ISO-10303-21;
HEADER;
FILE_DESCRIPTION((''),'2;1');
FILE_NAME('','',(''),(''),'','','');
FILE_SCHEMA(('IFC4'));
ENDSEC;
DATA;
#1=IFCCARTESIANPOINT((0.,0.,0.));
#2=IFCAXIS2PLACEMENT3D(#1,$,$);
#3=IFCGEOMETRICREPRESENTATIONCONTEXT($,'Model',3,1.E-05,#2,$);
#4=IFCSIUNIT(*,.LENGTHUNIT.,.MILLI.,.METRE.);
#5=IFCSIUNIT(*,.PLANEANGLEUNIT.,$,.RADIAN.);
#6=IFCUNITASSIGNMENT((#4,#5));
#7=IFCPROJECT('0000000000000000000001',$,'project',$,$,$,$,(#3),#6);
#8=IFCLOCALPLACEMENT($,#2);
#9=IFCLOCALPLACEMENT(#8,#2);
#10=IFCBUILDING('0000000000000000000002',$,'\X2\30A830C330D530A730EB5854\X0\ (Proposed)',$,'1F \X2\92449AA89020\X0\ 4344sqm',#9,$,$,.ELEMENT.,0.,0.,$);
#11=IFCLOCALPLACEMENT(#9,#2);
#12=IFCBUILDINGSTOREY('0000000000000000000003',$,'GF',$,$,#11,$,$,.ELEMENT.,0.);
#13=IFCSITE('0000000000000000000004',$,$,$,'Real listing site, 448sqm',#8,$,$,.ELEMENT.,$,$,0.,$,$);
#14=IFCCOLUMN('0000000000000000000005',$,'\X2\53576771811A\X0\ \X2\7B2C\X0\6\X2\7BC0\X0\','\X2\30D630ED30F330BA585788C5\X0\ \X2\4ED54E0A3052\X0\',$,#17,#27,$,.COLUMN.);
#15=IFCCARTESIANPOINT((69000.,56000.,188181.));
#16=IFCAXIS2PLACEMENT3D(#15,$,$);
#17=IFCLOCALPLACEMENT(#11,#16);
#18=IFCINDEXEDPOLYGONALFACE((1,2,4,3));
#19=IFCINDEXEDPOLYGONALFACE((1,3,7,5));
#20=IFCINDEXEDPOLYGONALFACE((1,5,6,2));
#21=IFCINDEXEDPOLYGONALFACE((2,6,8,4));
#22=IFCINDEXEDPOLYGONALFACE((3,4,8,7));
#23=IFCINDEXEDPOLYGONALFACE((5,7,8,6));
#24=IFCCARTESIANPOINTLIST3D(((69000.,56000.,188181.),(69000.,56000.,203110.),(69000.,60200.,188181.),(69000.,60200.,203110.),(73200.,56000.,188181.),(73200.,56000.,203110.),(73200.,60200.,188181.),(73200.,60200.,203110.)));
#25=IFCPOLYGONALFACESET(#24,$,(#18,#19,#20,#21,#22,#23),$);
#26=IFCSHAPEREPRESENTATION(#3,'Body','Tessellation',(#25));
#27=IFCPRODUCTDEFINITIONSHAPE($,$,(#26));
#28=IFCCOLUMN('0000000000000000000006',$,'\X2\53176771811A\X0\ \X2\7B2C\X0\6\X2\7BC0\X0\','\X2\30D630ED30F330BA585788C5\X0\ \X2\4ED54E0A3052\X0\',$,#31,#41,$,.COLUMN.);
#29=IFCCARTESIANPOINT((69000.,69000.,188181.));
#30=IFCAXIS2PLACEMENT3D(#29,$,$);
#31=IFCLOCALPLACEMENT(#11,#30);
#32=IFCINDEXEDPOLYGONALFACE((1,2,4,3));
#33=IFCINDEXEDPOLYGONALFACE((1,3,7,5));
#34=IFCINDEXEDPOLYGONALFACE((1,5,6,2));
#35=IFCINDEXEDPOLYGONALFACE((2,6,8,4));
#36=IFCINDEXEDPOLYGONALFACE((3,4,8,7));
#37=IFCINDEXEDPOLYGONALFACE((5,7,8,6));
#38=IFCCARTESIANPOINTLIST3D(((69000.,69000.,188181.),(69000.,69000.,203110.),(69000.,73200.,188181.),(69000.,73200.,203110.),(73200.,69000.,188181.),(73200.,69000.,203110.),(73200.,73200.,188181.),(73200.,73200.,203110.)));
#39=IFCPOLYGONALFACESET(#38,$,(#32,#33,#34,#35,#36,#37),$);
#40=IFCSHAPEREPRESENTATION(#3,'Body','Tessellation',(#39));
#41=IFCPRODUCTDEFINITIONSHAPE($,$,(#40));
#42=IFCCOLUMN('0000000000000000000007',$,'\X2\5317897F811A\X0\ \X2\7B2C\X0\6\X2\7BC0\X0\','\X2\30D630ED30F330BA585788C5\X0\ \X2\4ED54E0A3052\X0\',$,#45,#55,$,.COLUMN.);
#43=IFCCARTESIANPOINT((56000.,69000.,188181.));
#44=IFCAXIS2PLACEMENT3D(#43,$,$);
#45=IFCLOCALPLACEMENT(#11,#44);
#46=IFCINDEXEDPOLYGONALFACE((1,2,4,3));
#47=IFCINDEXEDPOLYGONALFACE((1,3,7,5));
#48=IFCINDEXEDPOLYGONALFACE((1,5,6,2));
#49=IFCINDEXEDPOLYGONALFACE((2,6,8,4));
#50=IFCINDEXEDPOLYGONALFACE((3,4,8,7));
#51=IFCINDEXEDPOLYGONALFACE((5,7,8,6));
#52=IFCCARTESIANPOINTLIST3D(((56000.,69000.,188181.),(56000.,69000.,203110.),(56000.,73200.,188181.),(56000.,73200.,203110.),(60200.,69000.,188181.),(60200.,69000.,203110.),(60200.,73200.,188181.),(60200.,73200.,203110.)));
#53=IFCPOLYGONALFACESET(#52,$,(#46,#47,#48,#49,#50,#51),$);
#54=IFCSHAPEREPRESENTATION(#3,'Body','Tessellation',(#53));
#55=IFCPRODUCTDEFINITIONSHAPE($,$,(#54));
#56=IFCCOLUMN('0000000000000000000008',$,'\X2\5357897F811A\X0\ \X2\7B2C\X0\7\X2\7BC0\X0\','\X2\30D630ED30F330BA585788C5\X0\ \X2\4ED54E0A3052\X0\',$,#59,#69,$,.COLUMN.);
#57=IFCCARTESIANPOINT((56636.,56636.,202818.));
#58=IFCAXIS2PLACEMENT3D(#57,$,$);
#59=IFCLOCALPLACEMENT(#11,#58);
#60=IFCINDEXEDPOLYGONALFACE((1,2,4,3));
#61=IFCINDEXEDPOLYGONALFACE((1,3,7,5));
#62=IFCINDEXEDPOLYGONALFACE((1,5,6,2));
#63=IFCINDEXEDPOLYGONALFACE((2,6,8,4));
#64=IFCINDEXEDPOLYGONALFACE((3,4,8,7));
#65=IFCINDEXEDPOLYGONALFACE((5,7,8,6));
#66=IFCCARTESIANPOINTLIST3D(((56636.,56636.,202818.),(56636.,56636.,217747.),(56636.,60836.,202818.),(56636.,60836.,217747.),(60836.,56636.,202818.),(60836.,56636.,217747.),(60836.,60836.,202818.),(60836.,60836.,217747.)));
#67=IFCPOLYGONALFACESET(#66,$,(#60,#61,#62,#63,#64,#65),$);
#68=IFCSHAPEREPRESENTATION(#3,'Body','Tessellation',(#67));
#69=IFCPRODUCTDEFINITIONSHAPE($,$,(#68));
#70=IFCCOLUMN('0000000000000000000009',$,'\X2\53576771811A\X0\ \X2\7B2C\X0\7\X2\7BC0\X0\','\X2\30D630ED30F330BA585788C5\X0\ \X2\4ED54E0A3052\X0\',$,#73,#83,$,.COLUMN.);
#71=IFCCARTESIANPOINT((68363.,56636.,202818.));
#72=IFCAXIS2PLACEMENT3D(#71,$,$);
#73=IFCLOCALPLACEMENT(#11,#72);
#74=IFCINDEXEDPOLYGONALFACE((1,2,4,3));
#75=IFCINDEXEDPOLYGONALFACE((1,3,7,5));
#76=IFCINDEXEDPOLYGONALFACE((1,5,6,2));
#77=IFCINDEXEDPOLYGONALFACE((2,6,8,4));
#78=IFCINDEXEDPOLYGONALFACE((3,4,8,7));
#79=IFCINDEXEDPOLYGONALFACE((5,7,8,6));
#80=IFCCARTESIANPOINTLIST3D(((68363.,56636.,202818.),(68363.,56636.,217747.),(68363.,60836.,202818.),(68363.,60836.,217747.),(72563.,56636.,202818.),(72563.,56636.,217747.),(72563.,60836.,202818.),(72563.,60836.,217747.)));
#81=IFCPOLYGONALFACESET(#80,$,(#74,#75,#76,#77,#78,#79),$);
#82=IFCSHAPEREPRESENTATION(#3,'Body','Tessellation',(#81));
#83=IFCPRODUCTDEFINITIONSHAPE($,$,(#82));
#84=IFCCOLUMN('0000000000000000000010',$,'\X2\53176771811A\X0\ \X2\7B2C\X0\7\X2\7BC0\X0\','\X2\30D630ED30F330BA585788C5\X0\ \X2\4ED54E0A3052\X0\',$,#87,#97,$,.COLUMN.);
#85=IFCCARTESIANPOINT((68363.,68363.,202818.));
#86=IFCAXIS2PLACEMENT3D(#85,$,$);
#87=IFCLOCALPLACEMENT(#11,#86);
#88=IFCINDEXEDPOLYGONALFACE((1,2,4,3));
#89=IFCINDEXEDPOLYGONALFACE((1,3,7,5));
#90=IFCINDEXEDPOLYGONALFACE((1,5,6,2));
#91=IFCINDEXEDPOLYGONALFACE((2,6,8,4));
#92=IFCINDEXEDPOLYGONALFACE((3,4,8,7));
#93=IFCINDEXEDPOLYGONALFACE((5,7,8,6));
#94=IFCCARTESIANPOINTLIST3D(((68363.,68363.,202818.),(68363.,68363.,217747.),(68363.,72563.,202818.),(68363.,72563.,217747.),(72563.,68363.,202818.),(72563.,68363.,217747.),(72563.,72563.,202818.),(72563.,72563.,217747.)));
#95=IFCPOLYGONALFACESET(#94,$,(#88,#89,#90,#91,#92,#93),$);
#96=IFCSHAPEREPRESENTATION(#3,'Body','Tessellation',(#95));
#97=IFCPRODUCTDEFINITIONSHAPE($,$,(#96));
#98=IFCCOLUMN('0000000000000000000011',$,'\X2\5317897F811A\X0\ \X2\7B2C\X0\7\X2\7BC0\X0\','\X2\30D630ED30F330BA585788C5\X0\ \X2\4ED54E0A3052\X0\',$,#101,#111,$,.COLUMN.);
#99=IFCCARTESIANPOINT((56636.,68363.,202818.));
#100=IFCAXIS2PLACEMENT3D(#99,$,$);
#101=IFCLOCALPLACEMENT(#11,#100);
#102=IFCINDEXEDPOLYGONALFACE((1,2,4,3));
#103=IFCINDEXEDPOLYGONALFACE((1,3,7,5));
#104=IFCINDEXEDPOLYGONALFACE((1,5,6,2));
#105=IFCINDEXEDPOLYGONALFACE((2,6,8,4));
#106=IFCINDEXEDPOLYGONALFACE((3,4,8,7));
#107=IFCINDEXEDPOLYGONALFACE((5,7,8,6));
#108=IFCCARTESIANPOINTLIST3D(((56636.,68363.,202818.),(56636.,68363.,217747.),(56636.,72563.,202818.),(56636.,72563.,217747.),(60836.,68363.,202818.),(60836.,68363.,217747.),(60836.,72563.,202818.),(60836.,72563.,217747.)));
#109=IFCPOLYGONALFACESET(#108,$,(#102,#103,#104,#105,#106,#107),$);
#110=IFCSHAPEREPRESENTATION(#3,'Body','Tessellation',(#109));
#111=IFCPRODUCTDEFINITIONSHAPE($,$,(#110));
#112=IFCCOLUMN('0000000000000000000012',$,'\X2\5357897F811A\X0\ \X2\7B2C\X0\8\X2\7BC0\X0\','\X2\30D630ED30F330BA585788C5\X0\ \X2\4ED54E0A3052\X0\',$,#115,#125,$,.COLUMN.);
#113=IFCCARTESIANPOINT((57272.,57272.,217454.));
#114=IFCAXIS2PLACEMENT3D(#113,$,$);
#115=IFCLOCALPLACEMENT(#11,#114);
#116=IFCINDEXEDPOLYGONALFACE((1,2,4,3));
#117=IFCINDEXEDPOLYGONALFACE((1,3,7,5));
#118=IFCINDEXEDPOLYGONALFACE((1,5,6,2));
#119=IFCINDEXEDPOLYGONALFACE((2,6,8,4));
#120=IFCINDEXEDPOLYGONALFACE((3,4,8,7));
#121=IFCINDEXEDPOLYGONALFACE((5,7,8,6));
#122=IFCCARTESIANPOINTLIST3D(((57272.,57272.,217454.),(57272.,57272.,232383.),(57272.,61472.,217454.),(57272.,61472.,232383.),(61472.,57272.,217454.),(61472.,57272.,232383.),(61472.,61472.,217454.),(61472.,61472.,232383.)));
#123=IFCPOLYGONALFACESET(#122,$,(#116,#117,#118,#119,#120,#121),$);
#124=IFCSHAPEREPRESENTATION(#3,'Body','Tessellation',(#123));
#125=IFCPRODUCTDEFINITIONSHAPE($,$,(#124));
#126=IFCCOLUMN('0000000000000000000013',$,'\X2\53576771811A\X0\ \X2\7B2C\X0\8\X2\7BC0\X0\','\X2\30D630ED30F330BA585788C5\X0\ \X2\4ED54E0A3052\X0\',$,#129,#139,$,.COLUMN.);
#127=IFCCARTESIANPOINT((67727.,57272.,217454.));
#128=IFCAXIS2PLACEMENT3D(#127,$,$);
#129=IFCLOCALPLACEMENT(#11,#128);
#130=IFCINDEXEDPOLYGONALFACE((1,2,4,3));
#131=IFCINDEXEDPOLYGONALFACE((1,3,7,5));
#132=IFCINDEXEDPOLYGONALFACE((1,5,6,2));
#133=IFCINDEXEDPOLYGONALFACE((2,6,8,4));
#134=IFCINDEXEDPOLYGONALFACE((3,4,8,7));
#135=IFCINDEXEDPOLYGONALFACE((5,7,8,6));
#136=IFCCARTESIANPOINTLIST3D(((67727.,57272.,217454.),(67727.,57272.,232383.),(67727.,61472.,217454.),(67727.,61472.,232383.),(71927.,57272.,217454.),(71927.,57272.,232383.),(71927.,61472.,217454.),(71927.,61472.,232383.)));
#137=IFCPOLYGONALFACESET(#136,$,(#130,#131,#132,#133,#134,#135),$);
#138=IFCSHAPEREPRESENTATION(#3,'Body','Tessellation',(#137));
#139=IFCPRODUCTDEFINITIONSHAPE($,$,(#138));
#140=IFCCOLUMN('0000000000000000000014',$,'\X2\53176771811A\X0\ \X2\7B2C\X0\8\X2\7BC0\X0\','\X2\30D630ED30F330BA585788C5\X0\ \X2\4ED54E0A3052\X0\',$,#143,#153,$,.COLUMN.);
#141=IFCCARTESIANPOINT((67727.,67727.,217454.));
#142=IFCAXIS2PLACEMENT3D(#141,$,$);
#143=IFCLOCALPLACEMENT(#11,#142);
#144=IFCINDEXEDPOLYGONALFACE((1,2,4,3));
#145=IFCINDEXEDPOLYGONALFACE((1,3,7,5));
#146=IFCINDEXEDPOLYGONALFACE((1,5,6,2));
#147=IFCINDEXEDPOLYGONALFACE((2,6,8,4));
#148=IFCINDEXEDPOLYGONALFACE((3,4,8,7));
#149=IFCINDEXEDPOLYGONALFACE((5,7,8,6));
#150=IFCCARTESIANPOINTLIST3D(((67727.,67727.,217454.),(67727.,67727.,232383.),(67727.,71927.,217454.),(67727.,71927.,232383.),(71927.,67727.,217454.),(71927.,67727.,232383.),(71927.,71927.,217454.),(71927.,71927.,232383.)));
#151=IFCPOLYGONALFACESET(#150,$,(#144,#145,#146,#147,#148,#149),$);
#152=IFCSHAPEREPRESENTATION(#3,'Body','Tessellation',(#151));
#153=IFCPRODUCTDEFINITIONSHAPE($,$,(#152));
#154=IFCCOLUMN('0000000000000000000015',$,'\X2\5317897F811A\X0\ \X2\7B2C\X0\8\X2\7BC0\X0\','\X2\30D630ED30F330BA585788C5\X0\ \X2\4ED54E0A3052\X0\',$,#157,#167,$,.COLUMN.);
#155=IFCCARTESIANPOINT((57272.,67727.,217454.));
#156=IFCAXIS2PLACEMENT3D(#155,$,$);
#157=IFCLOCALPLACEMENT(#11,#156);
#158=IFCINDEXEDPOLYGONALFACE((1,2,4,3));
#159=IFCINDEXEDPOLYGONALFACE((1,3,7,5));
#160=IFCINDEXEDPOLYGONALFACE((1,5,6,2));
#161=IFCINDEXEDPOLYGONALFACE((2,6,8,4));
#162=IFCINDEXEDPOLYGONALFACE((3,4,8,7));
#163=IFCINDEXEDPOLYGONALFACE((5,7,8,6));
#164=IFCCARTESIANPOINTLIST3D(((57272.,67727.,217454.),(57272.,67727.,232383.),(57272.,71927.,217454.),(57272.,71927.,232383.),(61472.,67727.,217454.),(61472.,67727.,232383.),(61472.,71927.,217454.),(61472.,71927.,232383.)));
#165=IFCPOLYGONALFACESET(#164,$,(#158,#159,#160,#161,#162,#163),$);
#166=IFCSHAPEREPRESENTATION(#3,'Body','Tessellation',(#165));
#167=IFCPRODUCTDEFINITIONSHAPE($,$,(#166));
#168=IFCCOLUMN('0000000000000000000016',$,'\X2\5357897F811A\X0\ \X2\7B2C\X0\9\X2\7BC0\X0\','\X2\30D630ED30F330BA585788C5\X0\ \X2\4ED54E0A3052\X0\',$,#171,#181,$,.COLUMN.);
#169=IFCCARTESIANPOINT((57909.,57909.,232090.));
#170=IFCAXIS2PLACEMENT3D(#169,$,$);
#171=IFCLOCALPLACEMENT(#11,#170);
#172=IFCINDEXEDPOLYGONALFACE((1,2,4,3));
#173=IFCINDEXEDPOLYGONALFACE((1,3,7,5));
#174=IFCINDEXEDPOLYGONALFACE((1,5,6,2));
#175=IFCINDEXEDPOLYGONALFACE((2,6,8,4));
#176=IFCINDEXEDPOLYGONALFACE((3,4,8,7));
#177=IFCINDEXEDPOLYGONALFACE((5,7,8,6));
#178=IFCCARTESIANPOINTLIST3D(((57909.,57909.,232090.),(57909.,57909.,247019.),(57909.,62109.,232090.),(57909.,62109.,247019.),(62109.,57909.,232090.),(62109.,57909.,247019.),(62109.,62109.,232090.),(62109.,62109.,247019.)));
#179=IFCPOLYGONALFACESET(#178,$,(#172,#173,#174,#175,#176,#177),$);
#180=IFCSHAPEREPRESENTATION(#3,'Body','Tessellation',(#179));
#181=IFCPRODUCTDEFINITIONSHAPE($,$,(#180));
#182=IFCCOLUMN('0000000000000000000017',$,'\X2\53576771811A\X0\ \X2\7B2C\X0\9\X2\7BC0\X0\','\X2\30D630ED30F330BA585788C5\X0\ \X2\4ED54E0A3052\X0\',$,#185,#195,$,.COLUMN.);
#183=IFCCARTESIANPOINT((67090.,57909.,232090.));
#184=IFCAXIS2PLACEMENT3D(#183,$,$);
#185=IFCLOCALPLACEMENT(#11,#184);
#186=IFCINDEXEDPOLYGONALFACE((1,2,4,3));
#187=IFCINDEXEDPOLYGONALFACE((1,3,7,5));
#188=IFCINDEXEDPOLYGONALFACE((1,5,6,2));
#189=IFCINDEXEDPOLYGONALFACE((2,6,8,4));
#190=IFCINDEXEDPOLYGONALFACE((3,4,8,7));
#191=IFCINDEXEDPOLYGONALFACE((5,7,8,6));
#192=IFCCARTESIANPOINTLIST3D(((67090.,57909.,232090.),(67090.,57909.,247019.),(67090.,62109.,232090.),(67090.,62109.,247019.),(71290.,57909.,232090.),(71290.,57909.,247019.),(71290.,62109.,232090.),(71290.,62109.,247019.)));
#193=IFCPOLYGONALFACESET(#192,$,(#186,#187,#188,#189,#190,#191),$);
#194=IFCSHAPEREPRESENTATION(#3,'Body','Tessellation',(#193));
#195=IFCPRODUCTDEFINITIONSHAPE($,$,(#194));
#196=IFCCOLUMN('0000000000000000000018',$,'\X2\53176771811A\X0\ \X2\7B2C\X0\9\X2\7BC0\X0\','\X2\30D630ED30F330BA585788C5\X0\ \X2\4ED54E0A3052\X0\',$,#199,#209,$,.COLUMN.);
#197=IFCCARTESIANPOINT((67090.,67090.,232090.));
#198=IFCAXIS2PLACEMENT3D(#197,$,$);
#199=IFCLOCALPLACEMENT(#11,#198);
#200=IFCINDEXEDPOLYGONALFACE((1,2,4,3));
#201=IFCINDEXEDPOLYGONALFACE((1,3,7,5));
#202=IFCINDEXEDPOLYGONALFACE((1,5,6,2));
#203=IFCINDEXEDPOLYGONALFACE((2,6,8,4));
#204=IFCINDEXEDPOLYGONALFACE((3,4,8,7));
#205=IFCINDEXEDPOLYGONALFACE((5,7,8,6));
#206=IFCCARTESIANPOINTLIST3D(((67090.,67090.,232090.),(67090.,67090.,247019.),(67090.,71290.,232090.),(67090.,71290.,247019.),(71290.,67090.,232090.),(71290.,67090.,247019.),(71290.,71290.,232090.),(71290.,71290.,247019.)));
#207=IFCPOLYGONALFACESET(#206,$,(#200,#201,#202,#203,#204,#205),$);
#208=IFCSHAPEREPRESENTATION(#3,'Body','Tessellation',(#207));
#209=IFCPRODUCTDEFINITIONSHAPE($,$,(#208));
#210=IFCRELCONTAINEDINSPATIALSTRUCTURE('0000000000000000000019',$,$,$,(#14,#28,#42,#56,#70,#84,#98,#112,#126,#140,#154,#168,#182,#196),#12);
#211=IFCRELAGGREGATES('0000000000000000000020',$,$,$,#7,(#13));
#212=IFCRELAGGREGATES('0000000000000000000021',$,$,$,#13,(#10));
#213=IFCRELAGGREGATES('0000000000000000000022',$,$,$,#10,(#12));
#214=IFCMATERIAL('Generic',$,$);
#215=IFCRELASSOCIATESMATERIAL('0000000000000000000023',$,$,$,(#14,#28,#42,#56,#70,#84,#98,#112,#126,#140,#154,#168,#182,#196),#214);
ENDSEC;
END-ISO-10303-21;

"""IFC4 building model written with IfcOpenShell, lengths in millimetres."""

from ifc_helpers import new_model, si_unit, frame, frame_2d, origin, place, context, project, spatial, rectangle, extrude, material, element, save


model = new_model("IFC4")

# Units and contexts
model_context = context("Model", 3, precision=1e-05, world=origin())
ifc_project = project(units=[si_unit("LENGTHUNIT", "METRE", prefix="MILLI"), si_unit("PLANEANGLEUNIT", "RADIAN")], contexts=[model_context])

# Site, building, storey
site_placement = place(None, origin())
site = spatial("IfcSite", under=ifc_project, at=site_placement, ObjectType="Real listing site, 448sqm", CompositionType="ELEMENT", RefElevation=0.0)
building_placement = place(site_placement, origin())
building = spatial("IfcBuilding", under=site, at=building_placement, Name="エッフェル塔 (Proposed)", ObjectType="1F 鉄骨造 4344sqm", CompositionType="ELEMENT", ElevationOfRefHeight=0.0, ElevationOfTerrain=0.0)
storey_placement = place(building_placement, origin())
storey = spatial("IfcBuildingStorey", under=building, at=storey_placement, Name="GF", CompositionType="ELEMENT", Elevation=0.0)

# Columns
ifc_material_1 = material(Name="Generic")
column_1_placement = place(storey_placement, frame((69000.0, 56000.0, 188181.0)))
element("IfcColumn", 1, at=column_1_placement, inside=storey, material=ifc_material_1, Name="南東脚 第6節", Description="ブロンズ塗装 仕上げ", PredefinedType="COLUMN", context=model_context, shape_type="SweptSolid", body=[
    extrude(rectangle(XDim=4200.0, YDim=4200.0, at=frame_2d((2100.0, 2100.0))), frame((69000.0, 56000.0, 188181.0)), (0.0, 0.0, 1.0), 14929.0),
])
column_2_placement = place(storey_placement, frame((69000.0, 69000.0, 188181.0)))
element("IfcColumn", 2, at=column_2_placement, inside=storey, material=ifc_material_1, Name="北東脚 第6節", Description="ブロンズ塗装 仕上げ", PredefinedType="COLUMN", context=model_context, shape_type="SweptSolid", body=[
    extrude(rectangle(XDim=4200.0, YDim=4200.0, at=frame_2d((2100.0, 2100.0))), frame((69000.0, 69000.0, 188181.0)), (0.0, 0.0, 1.0), 14929.0),
])
column_3_placement = place(storey_placement, frame((56000.0, 69000.0, 188181.0)))
element("IfcColumn", 3, at=column_3_placement, inside=storey, material=ifc_material_1, Name="北西脚 第6節", Description="ブロンズ塗装 仕上げ", PredefinedType="COLUMN", context=model_context, shape_type="SweptSolid", body=[
    extrude(rectangle(XDim=4200.0, YDim=4200.0, at=frame_2d((2100.0, 2100.0))), frame((56000.0, 69000.0, 188181.0)), (0.0, 0.0, 1.0), 14929.0),
])
column_4_placement = place(storey_placement, frame((56636.0, 56636.0, 202818.0)))
element("IfcColumn", 4, at=column_4_placement, inside=storey, material=ifc_material_1, Name="南西脚 第7節", Description="ブロンズ塗装 仕上げ", PredefinedType="COLUMN", context=model_context, shape_type="SweptSolid", body=[
    extrude(rectangle(XDim=4200.0, YDim=4200.0, at=frame_2d((2100.0, 2100.0))), frame((56636.0, 56636.0, 202818.0)), (0.0, 0.0, 1.0), 14929.0),
])
column_5_placement = place(storey_placement, frame((68363.0, 56636.0, 202818.0)))
element("IfcColumn", 5, at=column_5_placement, inside=storey, material=ifc_material_1, Name="南東脚 第7節", Description="ブロンズ塗装 仕上げ", PredefinedType="COLUMN", context=model_context, shape_type="SweptSolid", body=[
    extrude(rectangle(XDim=4200.0, YDim=4200.0, at=frame_2d((2100.0, 2100.0))), frame((68363.0, 56636.0, 202818.0)), (0.0, 0.0, 1.0), 14929.0),
])
column_6_placement = place(storey_placement, frame((68363.0, 68363.0, 202818.0)))
element("IfcColumn", 6, at=column_6_placement, inside=storey, material=ifc_material_1, Name="北東脚 第7節", Description="ブロンズ塗装 仕上げ", PredefinedType="COLUMN", context=model_context, shape_type="SweptSolid", body=[
    extrude(rectangle(XDim=4200.0, YDim=4200.0, at=frame_2d((2100.0, 2100.0))), frame((68363.0, 68363.0, 202818.0)), (0.0, 0.0, 1.0), 14929.0),
])
column_7_placement = place(storey_placement, frame((56636.0, 68363.0, 202818.0)))
element("IfcColumn", 7, at=column_7_placement, inside=storey, material=ifc_material_1, Name="北西脚 第7節", Description="ブロンズ塗装 仕上げ", PredefinedType="COLUMN", context=model_context, shape_type="SweptSolid", body=[
    extrude(rectangle(XDim=4200.0, YDim=4200.0, at=frame_2d((2100.0, 2100.0))), frame((56636.0, 68363.0, 202818.0)), (0.0, 0.0, 1.0), 14929.0),
])
column_8_placement = place(storey_placement, frame((57272.0, 57272.0, 217454.0)))
element("IfcColumn", 8, at=column_8_placement, inside=storey, material=ifc_material_1, Name="南西脚 第8節", Description="ブロンズ塗装 仕上げ", PredefinedType="COLUMN", context=model_context, shape_type="SweptSolid", body=[
    extrude(rectangle(XDim=4200.0, YDim=4200.0, at=frame_2d((2100.0, 2100.0))), frame((57272.0, 57272.0, 217454.0)), (0.0, 0.0, 1.0), 14929.0),
])
column_9_placement = place(storey_placement, frame((67727.0, 57272.0, 217454.0)))
element("IfcColumn", 9, at=column_9_placement, inside=storey, material=ifc_material_1, Name="南東脚 第8節", Description="ブロンズ塗装 仕上げ", PredefinedType="COLUMN", context=model_context, shape_type="SweptSolid", body=[
    extrude(rectangle(XDim=4200.0, YDim=4200.0, at=frame_2d((2100.0, 2100.0))), frame((67727.0, 57272.0, 217454.0)), (0.0, 0.0, 1.0), 14929.0),
])
column_10_placement = place(storey_placement, frame((67727.0, 67727.0, 217454.0)))
element("IfcColumn", 10, at=column_10_placement, inside=storey, material=ifc_material_1, Name="北東脚 第8節", Description="ブロンズ塗装 仕上げ", PredefinedType="COLUMN", context=model_context, shape_type="SweptSolid", body=[
    extrude(rectangle(XDim=4200.0, YDim=4200.0, at=frame_2d((2100.0, 2100.0))), frame((67727.0, 67727.0, 217454.0)), (0.0, 0.0, 1.0), 14929.0),
])
column_11_placement = place(storey_placement, frame((57272.0, 67727.0, 217454.0)))
element("IfcColumn", 11, at=column_11_placement, inside=storey, material=ifc_material_1, Name="北西脚 第8節", Description="ブロンズ塗装 仕上げ", PredefinedType="COLUMN", context=model_context, shape_type="SweptSolid", body=[
    extrude(rectangle(XDim=4200.0, YDim=4200.0, at=frame_2d((2100.0, 2100.0))), frame((57272.0, 67727.0, 217454.0)), (0.0, 0.0, 1.0), 14929.0),
])
column_12_placement = place(storey_placement, frame((57909.0, 57909.0, 232090.0)))
element("IfcColumn", 12, at=column_12_placement, inside=storey, material=ifc_material_1, Name="南西脚 第9節", Description="ブロンズ塗装 仕上げ", PredefinedType="COLUMN", context=model_context, shape_type="SweptSolid", body=[
    extrude(rectangle(XDim=4200.0, YDim=4200.0, at=frame_2d((2100.0, 2100.0))), frame((57909.0, 57909.0, 232090.0)), (0.0, 0.0, 1.0), 14929.0),
])
column_13_placement = place(storey_placement, frame((67090.0, 57909.0, 232090.0)))
element("IfcColumn", 13, at=column_13_placement, inside=storey, material=ifc_material_1, Name="南東脚 第9節", Description="ブロンズ塗装 仕上げ", PredefinedType="COLUMN", context=model_context, shape_type="SweptSolid", body=[
    extrude(rectangle(XDim=4200.0, YDim=4200.0, at=frame_2d((2100.0, 2100.0))), frame((67090.0, 57909.0, 232090.0)), (0.0, 0.0, 1.0), 14929.0),
])
column_14_placement = place(storey_placement, frame((67090.0, 67090.0, 232090.0)))
element("IfcColumn", 14, at=column_14_placement, inside=storey, material=ifc_material_1, Name="北東脚 第9節", Description="ブロンズ塗装 仕上げ", PredefinedType="COLUMN", context=model_context, shape_type="SweptSolid", body=[
    extrude(rectangle(XDim=4200.0, YDim=4200.0, at=frame_2d((2100.0, 2100.0))), frame((67090.0, 67090.0, 232090.0)), (0.0, 0.0, 1.0), 14929.0),
])

save(model, "model.ifc")
